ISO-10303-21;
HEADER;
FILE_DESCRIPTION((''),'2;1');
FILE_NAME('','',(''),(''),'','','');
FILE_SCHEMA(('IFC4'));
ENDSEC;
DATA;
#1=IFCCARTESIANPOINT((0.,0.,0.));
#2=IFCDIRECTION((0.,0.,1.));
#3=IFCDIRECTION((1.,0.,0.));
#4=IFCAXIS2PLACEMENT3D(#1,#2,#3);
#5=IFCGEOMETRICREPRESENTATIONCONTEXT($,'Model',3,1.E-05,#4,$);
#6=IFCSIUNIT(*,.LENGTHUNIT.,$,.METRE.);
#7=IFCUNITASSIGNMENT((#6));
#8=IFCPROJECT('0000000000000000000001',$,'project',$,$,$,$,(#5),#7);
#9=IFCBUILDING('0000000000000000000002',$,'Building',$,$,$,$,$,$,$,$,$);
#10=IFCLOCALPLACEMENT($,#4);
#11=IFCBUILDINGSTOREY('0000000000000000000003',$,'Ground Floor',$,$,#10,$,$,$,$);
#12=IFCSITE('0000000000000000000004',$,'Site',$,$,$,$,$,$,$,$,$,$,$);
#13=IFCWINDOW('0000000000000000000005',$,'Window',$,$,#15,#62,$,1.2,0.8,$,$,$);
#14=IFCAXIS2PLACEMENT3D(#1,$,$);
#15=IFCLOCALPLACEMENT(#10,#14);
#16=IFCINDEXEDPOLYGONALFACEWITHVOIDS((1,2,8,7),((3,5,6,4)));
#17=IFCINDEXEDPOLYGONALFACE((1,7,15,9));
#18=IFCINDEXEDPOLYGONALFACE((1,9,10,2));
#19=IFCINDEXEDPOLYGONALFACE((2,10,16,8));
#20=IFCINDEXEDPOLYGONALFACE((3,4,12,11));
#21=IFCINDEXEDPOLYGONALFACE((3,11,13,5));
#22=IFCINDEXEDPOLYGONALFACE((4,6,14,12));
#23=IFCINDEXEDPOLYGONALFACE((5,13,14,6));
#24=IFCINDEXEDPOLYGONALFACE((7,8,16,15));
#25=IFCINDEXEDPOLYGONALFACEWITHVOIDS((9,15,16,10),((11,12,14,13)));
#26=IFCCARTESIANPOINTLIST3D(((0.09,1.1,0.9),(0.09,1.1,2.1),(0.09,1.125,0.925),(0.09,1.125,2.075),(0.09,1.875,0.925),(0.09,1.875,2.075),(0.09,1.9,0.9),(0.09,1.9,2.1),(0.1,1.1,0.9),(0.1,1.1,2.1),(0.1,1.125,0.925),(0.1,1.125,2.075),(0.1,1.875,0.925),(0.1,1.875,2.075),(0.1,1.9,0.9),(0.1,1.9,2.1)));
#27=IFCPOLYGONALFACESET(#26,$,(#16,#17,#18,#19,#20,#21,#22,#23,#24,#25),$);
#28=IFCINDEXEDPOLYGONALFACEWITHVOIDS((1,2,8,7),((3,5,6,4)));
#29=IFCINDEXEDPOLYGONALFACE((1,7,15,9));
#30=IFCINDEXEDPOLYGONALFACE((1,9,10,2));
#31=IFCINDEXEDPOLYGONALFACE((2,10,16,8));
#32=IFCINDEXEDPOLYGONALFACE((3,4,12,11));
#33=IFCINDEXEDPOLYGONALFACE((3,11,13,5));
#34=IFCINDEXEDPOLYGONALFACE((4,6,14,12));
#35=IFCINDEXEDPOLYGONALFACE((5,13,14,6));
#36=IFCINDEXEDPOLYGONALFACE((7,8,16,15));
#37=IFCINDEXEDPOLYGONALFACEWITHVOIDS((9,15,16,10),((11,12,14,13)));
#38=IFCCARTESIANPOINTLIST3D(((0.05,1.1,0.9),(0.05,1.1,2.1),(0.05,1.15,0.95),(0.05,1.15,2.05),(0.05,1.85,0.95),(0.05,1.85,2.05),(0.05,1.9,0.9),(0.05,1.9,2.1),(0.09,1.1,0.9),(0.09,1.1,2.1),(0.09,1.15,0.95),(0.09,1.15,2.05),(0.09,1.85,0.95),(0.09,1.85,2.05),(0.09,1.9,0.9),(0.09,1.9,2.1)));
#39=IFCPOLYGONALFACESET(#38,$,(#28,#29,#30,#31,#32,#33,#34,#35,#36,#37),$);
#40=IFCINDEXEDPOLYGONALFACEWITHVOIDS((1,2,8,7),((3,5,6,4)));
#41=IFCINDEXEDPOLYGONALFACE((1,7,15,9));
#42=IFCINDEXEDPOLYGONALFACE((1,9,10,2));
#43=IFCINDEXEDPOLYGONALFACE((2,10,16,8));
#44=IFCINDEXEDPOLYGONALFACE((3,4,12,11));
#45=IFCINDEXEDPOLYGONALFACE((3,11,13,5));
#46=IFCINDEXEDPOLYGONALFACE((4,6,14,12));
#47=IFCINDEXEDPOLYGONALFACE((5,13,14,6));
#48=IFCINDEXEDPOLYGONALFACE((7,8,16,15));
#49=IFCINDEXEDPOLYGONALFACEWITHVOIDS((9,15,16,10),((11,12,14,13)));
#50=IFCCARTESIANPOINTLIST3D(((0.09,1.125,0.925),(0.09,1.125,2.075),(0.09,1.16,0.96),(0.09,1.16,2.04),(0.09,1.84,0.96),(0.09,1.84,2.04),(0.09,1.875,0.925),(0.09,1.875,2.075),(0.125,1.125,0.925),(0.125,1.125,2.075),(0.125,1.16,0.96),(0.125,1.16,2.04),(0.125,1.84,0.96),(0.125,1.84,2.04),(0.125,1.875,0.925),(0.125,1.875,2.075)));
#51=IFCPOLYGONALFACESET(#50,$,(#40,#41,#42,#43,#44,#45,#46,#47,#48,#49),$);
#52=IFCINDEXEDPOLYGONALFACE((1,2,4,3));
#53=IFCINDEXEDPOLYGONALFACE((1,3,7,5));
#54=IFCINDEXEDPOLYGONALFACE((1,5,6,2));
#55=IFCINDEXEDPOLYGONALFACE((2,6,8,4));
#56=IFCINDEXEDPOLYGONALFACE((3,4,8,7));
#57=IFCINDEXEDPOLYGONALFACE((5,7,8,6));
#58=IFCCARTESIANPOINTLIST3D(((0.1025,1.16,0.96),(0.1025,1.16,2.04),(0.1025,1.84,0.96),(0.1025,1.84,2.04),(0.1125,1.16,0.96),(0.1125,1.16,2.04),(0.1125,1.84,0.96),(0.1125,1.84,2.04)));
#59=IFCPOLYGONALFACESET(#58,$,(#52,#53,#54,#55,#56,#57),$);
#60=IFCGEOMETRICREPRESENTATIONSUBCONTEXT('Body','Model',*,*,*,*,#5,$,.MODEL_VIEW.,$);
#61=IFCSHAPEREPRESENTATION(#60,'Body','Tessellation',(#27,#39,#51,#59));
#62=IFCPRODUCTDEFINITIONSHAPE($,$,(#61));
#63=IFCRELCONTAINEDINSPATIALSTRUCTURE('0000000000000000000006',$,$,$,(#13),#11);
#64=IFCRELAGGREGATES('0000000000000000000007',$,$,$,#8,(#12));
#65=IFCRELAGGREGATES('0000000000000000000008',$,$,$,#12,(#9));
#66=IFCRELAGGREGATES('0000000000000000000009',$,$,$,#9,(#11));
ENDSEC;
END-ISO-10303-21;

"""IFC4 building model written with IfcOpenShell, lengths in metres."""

from ifc_helpers import new_model, si_unit, frame, origin_with_axes, place, context, subcontext, project, spatial, line, indexed_curve, outline, extrude, element, save


model = new_model("IFC4")

# Units and contexts
model_context = context("Model", 3, precision=1e-05, world=origin_with_axes())
body_context = subcontext(model_context, "Body", "Model", "MODEL_VIEW")
ifc_project = project(units=[si_unit("LENGTHUNIT", "METRE")], contexts=[model_context])

# Site, building, storey
site = spatial("IfcSite", under=ifc_project, Name="Site")
building = spatial("IfcBuilding", under=site, Name="Building")
storey_placement = place(None, origin_with_axes())
storey = spatial("IfcBuildingStorey", under=building, at=storey_placement, Name="Ground Floor")

# Window
window_placement = place(storey_placement, frame((0.0, 1.9, 0.9), z_axis=(0.0, 0.0, 1.0), x_axis=(0.0, -1.0, 0.0)))
element("IfcWindow", 1, at=window_placement, inside=storey, Name="Window", OverallHeight=1.2, OverallWidth=0.8, context=body_context, shape_type="SweptSolid", body=[
    extrude(outline(indexed_curve([(0.0, 0.0), (0.8, 0.0), (0.8, 1.2), (0.0, 1.2)], segments=[line(1, 2, 3, 4, 1)]), holes=[indexed_curve([(0.025, 0.025), (0.775, 0.025), (0.775, 1.175), (0.025, 1.175)], segments=[line(1, 2, 3, 4, 1)])]), frame((0.0, 0.09, 0.0), z_axis=(0.0, -1.0, 0.0), x_axis=(1.0, 0.0, 0.0)), (0.0, 0.0, -1.0), 0.01),
    extrude(outline(indexed_curve([(0.0, 0.0), (0.8, 0.0), (0.8, 1.2), (0.0, 1.2)], segments=[line(1, 2, 3, 4, 1)]), holes=[indexed_curve([(0.05, 0.05), (0.75, 0.05), (0.75, 1.15), (0.05, 1.15)], segments=[line(1, 2, 3, 4, 1)])]), frame((0.0, 0.05, 0.0), z_axis=(0.0, -1.0, 0.0), x_axis=(1.0, 0.0, 0.0)), (0.0, 0.0, -1.0), 0.04),
    extrude(outline(indexed_curve([(0.0, 0.0), (0.75, 0.0), (0.75, 1.15), (0.0, 1.15)], segments=[line(1, 2, 3, 4, 1)]), holes=[indexed_curve([(0.035, 0.035), (0.715, 0.035), (0.715, 1.115), (0.035, 1.115)], segments=[line(1, 2, 3, 4, 1)])]), frame((0.025, 0.09, 0.025), z_axis=(0.0, -1.0, 0.0), x_axis=(1.0, 0.0, 0.0)), (0.0, 0.0, -1.0), 0.035),
    extrude(outline(indexed_curve([(0.035, 0.035), (0.715, 0.035), (0.715, 1.115), (0.035, 1.115)], segments=[line(1, 2, 3, 4, 1)])), frame((0.025, 0.1025, 0.025), z_axis=(0.0, -1.0, 0.0), x_axis=(1.0, 0.0, 0.0)), (0.0, 0.0, -1.0), 0.01),
])

save(model, "model.ifc")
